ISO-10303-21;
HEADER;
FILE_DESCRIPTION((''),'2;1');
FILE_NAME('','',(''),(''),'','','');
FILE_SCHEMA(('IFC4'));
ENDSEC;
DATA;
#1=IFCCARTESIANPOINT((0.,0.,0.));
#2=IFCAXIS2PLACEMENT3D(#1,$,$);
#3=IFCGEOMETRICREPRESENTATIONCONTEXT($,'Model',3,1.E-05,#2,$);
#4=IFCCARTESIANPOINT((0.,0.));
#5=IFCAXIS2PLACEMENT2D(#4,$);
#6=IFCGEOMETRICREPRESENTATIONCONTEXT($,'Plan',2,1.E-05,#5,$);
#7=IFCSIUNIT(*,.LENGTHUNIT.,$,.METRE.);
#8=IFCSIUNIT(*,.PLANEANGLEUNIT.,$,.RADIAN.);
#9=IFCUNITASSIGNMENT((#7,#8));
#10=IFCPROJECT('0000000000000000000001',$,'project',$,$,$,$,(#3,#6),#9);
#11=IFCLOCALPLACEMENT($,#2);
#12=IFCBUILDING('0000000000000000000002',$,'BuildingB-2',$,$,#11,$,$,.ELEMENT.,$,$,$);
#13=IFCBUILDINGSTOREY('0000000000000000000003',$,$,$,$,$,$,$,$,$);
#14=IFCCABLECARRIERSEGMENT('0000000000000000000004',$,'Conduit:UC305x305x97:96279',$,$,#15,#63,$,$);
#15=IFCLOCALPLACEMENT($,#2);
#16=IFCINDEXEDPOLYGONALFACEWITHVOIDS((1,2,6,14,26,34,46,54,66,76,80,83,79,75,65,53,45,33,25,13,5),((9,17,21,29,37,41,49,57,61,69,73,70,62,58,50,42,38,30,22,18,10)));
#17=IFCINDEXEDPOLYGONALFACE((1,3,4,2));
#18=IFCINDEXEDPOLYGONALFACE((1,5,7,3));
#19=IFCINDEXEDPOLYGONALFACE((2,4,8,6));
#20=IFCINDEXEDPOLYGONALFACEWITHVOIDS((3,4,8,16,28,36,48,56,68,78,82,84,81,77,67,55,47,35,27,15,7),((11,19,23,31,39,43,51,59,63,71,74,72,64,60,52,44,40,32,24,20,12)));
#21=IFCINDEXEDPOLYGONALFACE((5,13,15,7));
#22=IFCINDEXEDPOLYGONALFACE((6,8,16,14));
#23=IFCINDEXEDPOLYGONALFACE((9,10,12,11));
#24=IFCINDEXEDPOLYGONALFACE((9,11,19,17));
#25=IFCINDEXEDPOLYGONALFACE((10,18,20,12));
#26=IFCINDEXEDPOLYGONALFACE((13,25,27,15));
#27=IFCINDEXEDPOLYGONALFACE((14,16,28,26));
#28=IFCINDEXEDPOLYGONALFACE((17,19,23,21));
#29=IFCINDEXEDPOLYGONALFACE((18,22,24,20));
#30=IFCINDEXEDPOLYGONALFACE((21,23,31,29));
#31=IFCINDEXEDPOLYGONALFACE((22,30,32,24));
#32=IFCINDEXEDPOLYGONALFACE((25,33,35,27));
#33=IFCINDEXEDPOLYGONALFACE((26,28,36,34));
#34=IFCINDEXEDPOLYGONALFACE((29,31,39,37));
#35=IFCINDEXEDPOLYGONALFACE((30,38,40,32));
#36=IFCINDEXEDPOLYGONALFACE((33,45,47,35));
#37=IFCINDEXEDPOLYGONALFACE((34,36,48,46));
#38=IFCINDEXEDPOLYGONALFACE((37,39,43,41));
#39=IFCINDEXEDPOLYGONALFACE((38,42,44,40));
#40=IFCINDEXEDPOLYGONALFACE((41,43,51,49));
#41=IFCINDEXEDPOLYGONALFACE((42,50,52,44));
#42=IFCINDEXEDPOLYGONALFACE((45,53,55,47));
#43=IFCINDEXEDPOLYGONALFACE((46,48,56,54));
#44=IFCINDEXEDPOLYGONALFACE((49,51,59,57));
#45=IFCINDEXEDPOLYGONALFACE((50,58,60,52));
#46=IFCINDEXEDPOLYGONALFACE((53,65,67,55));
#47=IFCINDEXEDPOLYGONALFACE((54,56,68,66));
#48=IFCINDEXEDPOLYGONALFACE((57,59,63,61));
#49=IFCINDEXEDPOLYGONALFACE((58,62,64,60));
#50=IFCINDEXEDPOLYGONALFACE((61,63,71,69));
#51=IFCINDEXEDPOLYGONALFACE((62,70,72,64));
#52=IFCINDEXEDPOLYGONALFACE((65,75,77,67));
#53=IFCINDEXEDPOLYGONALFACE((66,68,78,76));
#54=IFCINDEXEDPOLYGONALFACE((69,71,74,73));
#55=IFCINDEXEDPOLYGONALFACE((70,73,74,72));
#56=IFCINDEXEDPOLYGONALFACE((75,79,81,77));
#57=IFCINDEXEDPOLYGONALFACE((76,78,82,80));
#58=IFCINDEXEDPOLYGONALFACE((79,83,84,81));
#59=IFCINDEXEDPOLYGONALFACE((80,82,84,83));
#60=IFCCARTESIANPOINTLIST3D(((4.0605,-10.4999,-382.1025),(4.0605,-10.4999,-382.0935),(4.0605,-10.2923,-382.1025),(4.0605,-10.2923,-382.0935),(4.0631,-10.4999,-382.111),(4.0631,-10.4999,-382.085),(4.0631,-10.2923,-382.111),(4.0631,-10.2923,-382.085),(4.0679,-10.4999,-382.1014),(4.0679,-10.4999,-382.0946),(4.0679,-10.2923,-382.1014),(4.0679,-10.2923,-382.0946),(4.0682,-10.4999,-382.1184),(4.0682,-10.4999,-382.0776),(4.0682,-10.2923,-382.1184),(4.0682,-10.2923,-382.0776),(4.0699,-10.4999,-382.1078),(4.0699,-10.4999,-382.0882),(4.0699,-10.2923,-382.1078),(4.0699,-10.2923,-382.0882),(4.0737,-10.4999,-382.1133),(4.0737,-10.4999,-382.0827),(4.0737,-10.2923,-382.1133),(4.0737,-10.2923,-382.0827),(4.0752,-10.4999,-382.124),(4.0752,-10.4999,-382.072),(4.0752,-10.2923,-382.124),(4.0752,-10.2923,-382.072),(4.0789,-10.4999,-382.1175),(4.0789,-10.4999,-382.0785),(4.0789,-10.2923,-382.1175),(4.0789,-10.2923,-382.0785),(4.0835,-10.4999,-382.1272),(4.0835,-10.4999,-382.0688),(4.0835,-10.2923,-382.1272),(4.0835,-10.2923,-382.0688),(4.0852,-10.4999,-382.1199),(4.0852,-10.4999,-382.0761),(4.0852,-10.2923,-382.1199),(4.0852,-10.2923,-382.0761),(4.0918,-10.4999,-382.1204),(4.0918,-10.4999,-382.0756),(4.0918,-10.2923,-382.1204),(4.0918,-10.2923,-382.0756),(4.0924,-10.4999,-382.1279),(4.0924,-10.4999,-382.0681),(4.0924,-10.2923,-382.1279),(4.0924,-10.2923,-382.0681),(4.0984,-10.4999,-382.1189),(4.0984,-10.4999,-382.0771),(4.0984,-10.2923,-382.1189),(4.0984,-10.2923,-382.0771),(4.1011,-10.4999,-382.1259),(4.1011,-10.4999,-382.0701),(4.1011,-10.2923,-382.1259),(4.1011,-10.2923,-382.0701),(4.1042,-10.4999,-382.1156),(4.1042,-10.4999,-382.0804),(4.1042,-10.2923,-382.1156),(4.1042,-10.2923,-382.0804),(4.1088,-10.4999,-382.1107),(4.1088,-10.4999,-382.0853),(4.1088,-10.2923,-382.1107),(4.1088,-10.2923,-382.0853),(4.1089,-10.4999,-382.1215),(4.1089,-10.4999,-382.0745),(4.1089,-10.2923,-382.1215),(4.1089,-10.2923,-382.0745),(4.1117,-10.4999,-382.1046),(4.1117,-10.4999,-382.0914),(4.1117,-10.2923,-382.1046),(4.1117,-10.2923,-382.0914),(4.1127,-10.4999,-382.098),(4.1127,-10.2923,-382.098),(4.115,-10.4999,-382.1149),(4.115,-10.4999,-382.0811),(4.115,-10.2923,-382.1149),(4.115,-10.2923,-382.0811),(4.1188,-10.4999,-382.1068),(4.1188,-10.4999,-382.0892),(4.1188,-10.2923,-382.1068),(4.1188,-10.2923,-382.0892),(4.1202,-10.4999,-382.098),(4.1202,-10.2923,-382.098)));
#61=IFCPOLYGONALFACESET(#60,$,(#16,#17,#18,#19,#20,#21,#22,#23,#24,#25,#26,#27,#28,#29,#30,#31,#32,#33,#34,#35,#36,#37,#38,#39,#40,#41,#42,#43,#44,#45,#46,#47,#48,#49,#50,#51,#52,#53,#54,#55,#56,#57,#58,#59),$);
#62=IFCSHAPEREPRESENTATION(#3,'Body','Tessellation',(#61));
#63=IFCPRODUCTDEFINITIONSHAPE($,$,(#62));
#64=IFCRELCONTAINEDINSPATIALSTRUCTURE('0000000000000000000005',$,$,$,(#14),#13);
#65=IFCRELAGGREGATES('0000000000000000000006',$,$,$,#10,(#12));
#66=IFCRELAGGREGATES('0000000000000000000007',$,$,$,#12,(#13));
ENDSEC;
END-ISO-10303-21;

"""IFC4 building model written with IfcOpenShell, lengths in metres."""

from ifc_helpers import new_model, entity, si_unit, origin, origin_2d, place, context, project, spatial, element, save


model = new_model("IFC4")

# Units and contexts
model_context = context("Model", 3, precision=1e-05, world=origin())
plan_context = context("Plan", 2, precision=1e-05, world=origin_2d())
ifc_project = project(units=[si_unit("LENGTHUNIT", "METRE"), si_unit("PLANEANGLEUNIT", "RADIAN")], contexts=[model_context, plan_context])

# Building, storey
building_placement = place(None, origin())
building = spatial("IfcBuilding", under=ifc_project, at=building_placement, Name="BuildingB-2", CompositionType="ELEMENT")
storey = spatial("IfcBuildingStorey", under=building)

# Cable carrier segment
element("IfcCableCarrierSegment", 1, inside=storey, Name="Conduit:UC305x305x97:96279", context=model_context, shape_type="AdvancedSweptSolid", body=[
    entity("IfcSweptDiskSolid", entity("IfcCompositeCurve", [entity("IfcCompositeCurveSegment", "CONTINUOUS", False, entity("IfcPolyline", [entity("IfcCartesianPoint", [-4.0902, 10.2923, 382.098]), entity("IfcCartesianPoint", [-4.0902, 10.4999, 382.098])]))], False), 0.03, 0.0225),
])

save(model, "model.ifc")
